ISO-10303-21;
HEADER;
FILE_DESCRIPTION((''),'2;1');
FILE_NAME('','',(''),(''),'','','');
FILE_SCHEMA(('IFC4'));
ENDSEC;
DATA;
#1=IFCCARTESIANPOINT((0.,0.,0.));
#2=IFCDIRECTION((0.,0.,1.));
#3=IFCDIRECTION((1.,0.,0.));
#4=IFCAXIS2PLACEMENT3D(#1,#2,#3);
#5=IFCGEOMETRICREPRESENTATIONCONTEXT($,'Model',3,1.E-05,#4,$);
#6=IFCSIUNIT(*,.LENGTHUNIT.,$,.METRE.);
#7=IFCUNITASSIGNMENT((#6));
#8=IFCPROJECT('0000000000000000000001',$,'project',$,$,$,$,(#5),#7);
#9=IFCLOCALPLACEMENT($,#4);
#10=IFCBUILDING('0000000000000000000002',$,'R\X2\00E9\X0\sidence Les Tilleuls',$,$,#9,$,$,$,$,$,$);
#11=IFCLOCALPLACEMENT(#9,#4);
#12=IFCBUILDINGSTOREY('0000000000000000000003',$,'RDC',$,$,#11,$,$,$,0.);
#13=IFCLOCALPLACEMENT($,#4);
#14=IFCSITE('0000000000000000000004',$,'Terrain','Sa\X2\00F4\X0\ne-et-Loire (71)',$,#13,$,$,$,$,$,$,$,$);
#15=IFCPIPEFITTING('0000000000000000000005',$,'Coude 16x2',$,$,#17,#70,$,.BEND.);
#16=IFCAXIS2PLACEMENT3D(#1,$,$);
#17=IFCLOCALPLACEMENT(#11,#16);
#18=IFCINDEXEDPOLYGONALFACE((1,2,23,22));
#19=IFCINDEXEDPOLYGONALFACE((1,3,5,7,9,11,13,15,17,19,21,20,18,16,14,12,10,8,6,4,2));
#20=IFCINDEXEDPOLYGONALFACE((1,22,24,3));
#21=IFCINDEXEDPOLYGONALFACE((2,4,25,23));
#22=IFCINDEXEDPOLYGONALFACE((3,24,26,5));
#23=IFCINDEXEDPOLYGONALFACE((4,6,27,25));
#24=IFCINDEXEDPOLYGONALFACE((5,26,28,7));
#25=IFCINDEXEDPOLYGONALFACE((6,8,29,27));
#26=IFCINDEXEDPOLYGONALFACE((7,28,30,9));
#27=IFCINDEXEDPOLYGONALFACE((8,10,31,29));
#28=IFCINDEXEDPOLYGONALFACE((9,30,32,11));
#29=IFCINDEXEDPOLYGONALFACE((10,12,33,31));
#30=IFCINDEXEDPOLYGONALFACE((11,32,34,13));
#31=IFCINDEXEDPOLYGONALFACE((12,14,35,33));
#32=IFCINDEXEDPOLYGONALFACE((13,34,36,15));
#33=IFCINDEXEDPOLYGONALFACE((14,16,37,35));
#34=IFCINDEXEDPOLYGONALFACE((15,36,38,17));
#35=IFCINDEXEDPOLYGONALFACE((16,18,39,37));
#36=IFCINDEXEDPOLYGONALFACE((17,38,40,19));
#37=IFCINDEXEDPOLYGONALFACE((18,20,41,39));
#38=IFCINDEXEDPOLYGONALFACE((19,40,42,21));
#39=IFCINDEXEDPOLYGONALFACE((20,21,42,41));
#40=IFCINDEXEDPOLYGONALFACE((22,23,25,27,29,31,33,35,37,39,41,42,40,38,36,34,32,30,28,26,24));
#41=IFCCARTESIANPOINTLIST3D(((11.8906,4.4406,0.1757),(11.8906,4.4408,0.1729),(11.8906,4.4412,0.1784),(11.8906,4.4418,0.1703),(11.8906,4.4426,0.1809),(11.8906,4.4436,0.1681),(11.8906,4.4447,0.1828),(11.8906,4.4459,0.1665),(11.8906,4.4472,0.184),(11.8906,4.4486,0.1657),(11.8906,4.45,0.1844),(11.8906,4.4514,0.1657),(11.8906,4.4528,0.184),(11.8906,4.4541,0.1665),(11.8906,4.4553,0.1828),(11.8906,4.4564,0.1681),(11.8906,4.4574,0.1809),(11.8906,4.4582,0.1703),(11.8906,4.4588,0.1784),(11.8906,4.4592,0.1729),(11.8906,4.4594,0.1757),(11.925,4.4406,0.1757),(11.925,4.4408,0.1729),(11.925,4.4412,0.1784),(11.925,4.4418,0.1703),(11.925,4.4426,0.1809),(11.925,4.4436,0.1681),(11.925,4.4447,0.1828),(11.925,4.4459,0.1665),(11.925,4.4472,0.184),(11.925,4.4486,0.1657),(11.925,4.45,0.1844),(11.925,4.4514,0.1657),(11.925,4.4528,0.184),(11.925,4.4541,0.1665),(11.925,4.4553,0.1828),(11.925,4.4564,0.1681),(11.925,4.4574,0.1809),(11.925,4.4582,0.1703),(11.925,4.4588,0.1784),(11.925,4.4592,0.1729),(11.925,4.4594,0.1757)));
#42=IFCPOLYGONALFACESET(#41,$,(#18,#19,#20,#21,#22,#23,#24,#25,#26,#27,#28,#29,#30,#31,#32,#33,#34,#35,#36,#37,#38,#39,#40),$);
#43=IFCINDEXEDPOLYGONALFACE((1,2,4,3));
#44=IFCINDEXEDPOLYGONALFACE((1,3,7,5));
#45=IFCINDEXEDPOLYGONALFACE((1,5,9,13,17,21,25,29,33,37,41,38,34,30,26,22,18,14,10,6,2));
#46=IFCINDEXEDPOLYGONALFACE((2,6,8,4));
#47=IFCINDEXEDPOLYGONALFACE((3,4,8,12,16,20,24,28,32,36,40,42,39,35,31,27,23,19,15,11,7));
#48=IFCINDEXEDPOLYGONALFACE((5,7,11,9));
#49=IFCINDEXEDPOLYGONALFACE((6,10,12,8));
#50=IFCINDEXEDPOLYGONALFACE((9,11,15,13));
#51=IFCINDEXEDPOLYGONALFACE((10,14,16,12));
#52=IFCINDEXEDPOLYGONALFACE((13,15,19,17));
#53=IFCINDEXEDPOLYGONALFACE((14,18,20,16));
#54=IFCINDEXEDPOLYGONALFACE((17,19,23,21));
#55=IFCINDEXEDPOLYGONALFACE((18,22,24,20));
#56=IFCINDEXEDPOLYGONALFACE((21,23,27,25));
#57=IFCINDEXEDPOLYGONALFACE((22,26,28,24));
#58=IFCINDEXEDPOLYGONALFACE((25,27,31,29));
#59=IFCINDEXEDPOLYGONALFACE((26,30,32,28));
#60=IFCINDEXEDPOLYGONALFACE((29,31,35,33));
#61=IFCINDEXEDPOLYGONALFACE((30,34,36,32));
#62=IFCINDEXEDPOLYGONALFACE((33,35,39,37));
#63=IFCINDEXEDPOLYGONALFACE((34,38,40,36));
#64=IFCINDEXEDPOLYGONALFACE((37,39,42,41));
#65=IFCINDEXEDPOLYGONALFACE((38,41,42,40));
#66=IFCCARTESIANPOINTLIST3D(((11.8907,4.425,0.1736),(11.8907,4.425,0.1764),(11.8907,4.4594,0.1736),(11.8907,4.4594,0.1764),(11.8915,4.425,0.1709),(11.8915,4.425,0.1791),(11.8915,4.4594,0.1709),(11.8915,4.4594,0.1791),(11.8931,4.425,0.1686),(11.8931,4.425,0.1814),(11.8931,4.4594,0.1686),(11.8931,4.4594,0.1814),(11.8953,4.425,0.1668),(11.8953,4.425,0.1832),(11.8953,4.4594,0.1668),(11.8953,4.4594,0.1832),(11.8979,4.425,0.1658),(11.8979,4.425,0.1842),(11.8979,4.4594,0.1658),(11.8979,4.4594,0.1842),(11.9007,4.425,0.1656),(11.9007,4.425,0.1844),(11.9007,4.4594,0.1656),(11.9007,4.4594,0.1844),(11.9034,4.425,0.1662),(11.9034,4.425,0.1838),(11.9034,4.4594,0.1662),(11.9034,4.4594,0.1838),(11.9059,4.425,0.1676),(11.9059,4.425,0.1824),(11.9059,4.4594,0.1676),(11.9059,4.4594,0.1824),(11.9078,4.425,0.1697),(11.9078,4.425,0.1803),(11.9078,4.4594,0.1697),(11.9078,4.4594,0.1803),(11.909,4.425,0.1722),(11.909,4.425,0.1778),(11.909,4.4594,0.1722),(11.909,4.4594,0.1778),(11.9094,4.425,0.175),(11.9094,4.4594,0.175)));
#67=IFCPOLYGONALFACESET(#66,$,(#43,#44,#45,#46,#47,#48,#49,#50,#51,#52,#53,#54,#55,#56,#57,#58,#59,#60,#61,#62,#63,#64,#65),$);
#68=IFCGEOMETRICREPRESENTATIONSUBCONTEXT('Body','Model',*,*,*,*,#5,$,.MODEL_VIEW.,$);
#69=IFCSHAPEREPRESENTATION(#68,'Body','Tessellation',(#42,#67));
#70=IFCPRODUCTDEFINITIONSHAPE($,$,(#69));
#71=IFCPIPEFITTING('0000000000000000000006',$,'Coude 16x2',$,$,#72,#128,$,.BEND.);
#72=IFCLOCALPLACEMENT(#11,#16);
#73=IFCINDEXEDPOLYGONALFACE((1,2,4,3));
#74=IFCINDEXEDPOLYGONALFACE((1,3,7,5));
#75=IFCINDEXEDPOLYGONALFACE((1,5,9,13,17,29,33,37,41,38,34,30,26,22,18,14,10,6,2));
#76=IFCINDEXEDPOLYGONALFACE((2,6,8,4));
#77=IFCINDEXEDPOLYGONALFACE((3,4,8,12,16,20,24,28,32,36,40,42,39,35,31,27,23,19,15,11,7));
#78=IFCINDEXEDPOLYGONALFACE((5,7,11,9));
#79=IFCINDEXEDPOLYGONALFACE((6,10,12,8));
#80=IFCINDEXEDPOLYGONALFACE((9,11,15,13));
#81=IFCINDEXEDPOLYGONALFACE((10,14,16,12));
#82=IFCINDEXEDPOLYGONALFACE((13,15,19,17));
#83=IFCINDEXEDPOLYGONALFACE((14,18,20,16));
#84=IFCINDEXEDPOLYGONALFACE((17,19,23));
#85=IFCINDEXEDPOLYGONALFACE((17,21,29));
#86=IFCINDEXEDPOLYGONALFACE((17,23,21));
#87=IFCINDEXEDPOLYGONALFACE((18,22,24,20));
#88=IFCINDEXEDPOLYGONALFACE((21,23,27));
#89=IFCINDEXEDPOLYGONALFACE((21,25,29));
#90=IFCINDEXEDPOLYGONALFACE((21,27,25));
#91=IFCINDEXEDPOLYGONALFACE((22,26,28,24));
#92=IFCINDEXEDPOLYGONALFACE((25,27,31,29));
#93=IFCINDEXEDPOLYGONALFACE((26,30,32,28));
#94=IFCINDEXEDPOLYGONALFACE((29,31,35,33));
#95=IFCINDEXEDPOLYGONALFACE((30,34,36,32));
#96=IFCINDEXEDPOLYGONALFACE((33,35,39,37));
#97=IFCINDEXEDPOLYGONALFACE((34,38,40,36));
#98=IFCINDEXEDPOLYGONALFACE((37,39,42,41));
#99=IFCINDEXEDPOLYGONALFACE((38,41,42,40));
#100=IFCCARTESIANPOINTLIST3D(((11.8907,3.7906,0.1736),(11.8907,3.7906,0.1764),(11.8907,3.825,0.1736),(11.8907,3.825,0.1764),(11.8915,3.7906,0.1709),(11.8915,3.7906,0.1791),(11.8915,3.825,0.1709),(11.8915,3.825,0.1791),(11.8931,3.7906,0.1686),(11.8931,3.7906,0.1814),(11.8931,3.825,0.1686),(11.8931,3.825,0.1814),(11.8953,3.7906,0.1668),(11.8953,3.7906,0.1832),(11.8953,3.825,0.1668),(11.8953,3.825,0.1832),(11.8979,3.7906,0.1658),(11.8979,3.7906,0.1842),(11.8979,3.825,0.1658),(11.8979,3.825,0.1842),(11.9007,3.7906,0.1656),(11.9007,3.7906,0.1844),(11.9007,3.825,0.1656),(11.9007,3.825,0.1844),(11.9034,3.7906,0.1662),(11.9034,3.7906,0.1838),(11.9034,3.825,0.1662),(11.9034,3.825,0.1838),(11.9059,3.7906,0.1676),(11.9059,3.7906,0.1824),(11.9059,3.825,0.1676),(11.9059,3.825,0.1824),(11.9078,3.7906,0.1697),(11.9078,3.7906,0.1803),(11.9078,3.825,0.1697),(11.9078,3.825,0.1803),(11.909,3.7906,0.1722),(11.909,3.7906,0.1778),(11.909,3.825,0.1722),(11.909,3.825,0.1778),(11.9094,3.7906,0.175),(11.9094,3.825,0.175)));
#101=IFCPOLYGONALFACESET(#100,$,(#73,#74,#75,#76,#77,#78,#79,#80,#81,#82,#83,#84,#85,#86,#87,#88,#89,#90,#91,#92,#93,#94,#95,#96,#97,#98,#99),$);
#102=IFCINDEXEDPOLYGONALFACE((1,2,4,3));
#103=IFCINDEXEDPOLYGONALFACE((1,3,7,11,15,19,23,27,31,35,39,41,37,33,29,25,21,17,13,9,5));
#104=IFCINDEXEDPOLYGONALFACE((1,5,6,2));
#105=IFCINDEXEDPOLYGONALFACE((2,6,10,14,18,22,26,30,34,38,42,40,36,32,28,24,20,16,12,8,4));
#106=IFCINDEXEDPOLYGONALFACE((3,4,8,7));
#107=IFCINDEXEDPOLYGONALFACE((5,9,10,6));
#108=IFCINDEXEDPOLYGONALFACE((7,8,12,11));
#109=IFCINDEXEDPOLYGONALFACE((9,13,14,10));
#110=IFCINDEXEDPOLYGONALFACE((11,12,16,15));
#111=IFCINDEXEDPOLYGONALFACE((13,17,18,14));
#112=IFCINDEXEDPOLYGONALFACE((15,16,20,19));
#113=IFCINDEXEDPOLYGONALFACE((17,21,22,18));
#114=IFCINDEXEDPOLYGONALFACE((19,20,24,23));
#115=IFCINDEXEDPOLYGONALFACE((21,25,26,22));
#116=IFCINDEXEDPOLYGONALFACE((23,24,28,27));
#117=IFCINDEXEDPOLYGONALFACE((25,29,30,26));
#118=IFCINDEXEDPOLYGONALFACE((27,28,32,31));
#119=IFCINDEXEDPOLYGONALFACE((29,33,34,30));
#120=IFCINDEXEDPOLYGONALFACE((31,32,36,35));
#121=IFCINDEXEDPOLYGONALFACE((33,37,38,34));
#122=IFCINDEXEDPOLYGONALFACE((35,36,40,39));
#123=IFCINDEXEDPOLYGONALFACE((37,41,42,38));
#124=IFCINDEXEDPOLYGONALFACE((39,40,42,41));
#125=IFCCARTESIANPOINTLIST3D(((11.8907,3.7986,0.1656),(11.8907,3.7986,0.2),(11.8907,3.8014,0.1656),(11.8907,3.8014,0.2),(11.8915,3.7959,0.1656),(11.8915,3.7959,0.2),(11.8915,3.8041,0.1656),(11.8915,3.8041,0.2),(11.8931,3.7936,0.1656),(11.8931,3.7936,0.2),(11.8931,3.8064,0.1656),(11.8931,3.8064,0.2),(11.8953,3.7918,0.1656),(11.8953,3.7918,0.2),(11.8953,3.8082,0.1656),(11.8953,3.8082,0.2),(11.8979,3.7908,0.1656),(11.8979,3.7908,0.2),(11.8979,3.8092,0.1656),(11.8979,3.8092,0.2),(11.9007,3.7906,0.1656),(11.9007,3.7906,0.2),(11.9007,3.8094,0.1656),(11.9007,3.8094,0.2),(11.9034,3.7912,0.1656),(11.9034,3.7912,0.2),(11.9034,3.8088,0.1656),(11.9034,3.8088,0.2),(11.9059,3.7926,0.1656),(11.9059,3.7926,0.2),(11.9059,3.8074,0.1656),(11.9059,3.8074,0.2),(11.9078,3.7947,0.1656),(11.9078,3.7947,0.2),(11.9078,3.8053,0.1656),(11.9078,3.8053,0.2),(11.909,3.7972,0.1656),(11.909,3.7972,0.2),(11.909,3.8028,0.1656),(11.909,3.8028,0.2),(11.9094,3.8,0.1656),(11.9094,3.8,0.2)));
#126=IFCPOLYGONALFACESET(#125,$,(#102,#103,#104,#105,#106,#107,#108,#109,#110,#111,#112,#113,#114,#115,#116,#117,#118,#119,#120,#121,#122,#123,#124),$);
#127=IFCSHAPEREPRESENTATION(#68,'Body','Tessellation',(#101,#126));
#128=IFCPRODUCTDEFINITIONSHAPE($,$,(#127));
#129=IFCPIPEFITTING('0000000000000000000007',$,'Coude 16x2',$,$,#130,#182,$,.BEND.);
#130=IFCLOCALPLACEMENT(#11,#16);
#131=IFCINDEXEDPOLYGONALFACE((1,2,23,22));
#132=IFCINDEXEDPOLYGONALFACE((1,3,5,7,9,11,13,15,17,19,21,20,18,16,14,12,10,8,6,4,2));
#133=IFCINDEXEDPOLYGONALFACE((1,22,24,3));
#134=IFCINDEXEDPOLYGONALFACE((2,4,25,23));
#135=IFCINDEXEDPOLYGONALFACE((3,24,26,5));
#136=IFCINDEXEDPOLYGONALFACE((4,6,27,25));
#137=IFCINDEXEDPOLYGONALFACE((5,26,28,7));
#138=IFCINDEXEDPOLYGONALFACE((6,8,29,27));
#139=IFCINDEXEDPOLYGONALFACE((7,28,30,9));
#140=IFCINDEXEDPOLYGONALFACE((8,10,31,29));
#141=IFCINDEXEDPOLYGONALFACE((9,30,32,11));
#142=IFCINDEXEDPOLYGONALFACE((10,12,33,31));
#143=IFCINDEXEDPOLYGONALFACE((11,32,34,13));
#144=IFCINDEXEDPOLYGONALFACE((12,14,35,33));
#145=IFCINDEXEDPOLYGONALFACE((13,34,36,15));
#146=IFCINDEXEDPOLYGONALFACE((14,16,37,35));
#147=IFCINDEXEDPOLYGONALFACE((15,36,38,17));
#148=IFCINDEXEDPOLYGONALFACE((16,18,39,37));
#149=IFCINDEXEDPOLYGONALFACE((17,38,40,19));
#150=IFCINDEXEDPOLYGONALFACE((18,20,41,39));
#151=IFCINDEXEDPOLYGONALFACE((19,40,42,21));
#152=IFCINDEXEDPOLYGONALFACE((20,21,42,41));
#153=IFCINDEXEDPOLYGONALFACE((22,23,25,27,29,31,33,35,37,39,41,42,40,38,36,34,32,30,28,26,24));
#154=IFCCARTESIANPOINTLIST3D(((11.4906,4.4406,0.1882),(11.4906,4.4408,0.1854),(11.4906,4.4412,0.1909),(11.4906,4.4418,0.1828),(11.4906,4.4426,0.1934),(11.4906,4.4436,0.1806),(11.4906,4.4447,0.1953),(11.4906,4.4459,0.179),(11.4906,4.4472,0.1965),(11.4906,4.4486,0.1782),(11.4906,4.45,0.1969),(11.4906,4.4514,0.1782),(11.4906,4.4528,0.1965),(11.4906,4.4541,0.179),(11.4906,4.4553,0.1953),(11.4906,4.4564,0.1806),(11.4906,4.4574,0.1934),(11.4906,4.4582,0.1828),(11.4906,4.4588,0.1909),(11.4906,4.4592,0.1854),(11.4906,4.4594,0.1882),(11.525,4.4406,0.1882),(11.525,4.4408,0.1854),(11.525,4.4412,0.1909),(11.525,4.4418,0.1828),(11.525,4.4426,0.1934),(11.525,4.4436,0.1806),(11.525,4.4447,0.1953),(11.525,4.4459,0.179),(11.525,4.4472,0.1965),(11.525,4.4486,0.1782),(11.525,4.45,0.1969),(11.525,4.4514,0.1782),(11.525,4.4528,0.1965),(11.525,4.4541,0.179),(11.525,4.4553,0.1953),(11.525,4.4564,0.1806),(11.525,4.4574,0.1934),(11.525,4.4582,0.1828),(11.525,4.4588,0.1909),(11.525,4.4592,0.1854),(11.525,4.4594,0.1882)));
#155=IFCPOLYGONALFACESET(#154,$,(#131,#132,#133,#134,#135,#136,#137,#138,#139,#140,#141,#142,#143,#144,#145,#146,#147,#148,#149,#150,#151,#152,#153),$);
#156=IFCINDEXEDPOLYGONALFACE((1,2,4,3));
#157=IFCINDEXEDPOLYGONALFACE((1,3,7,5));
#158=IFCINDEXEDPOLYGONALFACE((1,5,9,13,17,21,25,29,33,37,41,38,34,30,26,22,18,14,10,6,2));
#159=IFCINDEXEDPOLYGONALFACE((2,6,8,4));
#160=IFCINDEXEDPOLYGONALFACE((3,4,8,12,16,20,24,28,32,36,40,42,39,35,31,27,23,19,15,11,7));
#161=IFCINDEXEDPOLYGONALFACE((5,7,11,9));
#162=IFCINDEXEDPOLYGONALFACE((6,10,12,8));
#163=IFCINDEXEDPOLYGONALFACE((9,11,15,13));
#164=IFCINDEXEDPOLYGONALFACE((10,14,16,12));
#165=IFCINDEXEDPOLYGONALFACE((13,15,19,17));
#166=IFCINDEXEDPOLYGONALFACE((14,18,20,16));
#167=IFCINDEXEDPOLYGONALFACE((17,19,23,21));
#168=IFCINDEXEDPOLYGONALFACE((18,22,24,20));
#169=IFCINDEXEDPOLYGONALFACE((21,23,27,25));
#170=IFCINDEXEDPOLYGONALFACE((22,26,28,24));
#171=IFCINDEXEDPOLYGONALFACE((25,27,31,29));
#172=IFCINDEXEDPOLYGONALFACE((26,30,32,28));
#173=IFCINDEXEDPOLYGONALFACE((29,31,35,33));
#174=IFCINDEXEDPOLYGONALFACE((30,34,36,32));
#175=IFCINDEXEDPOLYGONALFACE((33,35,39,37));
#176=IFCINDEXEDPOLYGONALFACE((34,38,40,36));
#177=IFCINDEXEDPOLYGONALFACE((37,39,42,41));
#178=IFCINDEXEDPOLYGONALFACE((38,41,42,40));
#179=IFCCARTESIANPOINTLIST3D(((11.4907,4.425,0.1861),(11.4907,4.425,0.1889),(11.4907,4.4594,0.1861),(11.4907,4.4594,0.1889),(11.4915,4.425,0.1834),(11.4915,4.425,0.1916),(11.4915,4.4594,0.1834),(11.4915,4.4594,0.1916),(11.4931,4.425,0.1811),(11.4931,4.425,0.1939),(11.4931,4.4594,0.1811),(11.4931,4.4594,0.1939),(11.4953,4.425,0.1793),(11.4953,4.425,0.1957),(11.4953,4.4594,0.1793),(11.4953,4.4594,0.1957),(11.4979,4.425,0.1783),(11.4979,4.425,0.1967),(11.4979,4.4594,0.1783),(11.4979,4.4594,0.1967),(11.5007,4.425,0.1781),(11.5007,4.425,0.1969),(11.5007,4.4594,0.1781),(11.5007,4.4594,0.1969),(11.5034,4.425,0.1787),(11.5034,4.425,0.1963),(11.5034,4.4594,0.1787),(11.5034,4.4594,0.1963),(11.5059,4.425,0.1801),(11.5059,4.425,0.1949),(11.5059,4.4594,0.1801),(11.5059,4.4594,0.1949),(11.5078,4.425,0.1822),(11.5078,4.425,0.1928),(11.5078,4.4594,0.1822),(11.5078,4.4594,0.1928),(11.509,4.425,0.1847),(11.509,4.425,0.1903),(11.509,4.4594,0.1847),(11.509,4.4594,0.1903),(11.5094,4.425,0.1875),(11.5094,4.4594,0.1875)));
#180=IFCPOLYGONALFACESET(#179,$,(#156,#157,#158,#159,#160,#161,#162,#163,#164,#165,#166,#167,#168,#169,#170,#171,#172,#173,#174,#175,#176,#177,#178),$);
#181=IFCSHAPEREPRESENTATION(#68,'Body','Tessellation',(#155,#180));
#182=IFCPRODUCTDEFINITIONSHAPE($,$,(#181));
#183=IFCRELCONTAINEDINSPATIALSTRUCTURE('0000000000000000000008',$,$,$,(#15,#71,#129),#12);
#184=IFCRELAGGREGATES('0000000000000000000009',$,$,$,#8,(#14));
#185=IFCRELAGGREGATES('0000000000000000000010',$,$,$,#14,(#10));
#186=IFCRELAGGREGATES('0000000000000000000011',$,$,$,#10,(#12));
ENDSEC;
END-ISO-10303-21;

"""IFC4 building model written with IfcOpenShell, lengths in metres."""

from ifc_helpers import new_model, si_unit, frame, origin_with_axes, place, context, subcontext, project, spatial, circle, extrude, element, save


model = new_model("IFC4")

# Units and contexts
model_context = context("Model", 3, precision=1e-05, world=origin_with_axes())
body_context = subcontext(model_context, "Body", "Model", "MODEL_VIEW")
ifc_project = project(units=[si_unit("LENGTHUNIT", "METRE")], contexts=[model_context])

# Site, building, storey
site_placement = place(None, origin_with_axes())
site = spatial("IfcSite", under=ifc_project, at=site_placement, Name="Terrain", Description="Saône-et-Loire (71)")
building_placement = place(None, origin_with_axes())
building = spatial("IfcBuilding", under=site, at=building_placement, Name="Résidence Les Tilleuls")
storey_placement = place(building_placement, origin_with_axes())
storey = spatial("IfcBuildingStorey", under=building, at=storey_placement, Name="RDC", Elevation=0.0)

# Pipe fittings
pipe_fitting_1_placement = place(storey_placement, frame((11.9, 4.45, 0.175), z_axis=(0.0, 0.0, 1.0), x_axis=(1.0, 0.0, 0.0)))
element("IfcPipeFitting", 1, at=pipe_fitting_1_placement, inside=storey, Name="Coude 16x2", PredefinedType="BEND", context=body_context, shape_type="SweptSolid", body=[
    extrude(circle(Radius=0.0094), frame((-0.0094, 0.0, 0.0), z_axis=(1.0, 0.0, 0.0), x_axis=(0.0, 0.0, 1.0)), (0.0, 0.0, 1.0), 0.0344),
    extrude(circle(Radius=0.0094), frame((0.0, 0.0094, 0.0), z_axis=(0.0, -1.0, 0.0), x_axis=(1.0, 0.0, 0.0)), (0.0, 0.0, 1.0), 0.0344),
])
pipe_fitting_2_placement = place(storey_placement, frame((11.9, 3.8, 0.175), z_axis=(0.0, 0.0, 1.0), x_axis=(1.0, 0.0, 0.0)))
element("IfcPipeFitting", 2, at=pipe_fitting_2_placement, inside=storey, Name="Coude 16x2", PredefinedType="BEND", context=body_context, shape_type="SweptSolid", body=[
    extrude(circle(Radius=0.0094), frame((0.0, -0.0094, 0.0), z_axis=(0.0, 1.0, 0.0), x_axis=(1.0, 0.0, 0.0)), (0.0, 0.0, 1.0), 0.0344),
    extrude(circle(Radius=0.0094), frame((0.0, 0.0, -0.0094), z_axis=(0.0, 0.0, 1.0), x_axis=(1.0, 0.0, 0.0)), (0.0, 0.0, 1.0), 0.0344),
])
pipe_fitting_3_placement = place(storey_placement, frame((11.5, 4.45, 0.1875), z_axis=(0.0, 0.0, 1.0), x_axis=(1.0, 0.0, 0.0)))
element("IfcPipeFitting", 3, at=pipe_fitting_3_placement, inside=storey, Name="Coude 16x2", PredefinedType="BEND", context=body_context, shape_type="SweptSolid", body=[
    extrude(circle(Radius=0.0094), frame((-0.0094, 0.0, 0.0), z_axis=(1.0, 0.0, 0.0), x_axis=(0.0, 0.0, 1.0)), (0.0, 0.0, 1.0), 0.0344),
    extrude(circle(Radius=0.0094), frame((0.0, 0.0094, 0.0), z_axis=(0.0, -1.0, 0.0), x_axis=(1.0, 0.0, 0.0)), (0.0, 0.0, 1.0), 0.0344),
])

save(model, "model.ifc")
